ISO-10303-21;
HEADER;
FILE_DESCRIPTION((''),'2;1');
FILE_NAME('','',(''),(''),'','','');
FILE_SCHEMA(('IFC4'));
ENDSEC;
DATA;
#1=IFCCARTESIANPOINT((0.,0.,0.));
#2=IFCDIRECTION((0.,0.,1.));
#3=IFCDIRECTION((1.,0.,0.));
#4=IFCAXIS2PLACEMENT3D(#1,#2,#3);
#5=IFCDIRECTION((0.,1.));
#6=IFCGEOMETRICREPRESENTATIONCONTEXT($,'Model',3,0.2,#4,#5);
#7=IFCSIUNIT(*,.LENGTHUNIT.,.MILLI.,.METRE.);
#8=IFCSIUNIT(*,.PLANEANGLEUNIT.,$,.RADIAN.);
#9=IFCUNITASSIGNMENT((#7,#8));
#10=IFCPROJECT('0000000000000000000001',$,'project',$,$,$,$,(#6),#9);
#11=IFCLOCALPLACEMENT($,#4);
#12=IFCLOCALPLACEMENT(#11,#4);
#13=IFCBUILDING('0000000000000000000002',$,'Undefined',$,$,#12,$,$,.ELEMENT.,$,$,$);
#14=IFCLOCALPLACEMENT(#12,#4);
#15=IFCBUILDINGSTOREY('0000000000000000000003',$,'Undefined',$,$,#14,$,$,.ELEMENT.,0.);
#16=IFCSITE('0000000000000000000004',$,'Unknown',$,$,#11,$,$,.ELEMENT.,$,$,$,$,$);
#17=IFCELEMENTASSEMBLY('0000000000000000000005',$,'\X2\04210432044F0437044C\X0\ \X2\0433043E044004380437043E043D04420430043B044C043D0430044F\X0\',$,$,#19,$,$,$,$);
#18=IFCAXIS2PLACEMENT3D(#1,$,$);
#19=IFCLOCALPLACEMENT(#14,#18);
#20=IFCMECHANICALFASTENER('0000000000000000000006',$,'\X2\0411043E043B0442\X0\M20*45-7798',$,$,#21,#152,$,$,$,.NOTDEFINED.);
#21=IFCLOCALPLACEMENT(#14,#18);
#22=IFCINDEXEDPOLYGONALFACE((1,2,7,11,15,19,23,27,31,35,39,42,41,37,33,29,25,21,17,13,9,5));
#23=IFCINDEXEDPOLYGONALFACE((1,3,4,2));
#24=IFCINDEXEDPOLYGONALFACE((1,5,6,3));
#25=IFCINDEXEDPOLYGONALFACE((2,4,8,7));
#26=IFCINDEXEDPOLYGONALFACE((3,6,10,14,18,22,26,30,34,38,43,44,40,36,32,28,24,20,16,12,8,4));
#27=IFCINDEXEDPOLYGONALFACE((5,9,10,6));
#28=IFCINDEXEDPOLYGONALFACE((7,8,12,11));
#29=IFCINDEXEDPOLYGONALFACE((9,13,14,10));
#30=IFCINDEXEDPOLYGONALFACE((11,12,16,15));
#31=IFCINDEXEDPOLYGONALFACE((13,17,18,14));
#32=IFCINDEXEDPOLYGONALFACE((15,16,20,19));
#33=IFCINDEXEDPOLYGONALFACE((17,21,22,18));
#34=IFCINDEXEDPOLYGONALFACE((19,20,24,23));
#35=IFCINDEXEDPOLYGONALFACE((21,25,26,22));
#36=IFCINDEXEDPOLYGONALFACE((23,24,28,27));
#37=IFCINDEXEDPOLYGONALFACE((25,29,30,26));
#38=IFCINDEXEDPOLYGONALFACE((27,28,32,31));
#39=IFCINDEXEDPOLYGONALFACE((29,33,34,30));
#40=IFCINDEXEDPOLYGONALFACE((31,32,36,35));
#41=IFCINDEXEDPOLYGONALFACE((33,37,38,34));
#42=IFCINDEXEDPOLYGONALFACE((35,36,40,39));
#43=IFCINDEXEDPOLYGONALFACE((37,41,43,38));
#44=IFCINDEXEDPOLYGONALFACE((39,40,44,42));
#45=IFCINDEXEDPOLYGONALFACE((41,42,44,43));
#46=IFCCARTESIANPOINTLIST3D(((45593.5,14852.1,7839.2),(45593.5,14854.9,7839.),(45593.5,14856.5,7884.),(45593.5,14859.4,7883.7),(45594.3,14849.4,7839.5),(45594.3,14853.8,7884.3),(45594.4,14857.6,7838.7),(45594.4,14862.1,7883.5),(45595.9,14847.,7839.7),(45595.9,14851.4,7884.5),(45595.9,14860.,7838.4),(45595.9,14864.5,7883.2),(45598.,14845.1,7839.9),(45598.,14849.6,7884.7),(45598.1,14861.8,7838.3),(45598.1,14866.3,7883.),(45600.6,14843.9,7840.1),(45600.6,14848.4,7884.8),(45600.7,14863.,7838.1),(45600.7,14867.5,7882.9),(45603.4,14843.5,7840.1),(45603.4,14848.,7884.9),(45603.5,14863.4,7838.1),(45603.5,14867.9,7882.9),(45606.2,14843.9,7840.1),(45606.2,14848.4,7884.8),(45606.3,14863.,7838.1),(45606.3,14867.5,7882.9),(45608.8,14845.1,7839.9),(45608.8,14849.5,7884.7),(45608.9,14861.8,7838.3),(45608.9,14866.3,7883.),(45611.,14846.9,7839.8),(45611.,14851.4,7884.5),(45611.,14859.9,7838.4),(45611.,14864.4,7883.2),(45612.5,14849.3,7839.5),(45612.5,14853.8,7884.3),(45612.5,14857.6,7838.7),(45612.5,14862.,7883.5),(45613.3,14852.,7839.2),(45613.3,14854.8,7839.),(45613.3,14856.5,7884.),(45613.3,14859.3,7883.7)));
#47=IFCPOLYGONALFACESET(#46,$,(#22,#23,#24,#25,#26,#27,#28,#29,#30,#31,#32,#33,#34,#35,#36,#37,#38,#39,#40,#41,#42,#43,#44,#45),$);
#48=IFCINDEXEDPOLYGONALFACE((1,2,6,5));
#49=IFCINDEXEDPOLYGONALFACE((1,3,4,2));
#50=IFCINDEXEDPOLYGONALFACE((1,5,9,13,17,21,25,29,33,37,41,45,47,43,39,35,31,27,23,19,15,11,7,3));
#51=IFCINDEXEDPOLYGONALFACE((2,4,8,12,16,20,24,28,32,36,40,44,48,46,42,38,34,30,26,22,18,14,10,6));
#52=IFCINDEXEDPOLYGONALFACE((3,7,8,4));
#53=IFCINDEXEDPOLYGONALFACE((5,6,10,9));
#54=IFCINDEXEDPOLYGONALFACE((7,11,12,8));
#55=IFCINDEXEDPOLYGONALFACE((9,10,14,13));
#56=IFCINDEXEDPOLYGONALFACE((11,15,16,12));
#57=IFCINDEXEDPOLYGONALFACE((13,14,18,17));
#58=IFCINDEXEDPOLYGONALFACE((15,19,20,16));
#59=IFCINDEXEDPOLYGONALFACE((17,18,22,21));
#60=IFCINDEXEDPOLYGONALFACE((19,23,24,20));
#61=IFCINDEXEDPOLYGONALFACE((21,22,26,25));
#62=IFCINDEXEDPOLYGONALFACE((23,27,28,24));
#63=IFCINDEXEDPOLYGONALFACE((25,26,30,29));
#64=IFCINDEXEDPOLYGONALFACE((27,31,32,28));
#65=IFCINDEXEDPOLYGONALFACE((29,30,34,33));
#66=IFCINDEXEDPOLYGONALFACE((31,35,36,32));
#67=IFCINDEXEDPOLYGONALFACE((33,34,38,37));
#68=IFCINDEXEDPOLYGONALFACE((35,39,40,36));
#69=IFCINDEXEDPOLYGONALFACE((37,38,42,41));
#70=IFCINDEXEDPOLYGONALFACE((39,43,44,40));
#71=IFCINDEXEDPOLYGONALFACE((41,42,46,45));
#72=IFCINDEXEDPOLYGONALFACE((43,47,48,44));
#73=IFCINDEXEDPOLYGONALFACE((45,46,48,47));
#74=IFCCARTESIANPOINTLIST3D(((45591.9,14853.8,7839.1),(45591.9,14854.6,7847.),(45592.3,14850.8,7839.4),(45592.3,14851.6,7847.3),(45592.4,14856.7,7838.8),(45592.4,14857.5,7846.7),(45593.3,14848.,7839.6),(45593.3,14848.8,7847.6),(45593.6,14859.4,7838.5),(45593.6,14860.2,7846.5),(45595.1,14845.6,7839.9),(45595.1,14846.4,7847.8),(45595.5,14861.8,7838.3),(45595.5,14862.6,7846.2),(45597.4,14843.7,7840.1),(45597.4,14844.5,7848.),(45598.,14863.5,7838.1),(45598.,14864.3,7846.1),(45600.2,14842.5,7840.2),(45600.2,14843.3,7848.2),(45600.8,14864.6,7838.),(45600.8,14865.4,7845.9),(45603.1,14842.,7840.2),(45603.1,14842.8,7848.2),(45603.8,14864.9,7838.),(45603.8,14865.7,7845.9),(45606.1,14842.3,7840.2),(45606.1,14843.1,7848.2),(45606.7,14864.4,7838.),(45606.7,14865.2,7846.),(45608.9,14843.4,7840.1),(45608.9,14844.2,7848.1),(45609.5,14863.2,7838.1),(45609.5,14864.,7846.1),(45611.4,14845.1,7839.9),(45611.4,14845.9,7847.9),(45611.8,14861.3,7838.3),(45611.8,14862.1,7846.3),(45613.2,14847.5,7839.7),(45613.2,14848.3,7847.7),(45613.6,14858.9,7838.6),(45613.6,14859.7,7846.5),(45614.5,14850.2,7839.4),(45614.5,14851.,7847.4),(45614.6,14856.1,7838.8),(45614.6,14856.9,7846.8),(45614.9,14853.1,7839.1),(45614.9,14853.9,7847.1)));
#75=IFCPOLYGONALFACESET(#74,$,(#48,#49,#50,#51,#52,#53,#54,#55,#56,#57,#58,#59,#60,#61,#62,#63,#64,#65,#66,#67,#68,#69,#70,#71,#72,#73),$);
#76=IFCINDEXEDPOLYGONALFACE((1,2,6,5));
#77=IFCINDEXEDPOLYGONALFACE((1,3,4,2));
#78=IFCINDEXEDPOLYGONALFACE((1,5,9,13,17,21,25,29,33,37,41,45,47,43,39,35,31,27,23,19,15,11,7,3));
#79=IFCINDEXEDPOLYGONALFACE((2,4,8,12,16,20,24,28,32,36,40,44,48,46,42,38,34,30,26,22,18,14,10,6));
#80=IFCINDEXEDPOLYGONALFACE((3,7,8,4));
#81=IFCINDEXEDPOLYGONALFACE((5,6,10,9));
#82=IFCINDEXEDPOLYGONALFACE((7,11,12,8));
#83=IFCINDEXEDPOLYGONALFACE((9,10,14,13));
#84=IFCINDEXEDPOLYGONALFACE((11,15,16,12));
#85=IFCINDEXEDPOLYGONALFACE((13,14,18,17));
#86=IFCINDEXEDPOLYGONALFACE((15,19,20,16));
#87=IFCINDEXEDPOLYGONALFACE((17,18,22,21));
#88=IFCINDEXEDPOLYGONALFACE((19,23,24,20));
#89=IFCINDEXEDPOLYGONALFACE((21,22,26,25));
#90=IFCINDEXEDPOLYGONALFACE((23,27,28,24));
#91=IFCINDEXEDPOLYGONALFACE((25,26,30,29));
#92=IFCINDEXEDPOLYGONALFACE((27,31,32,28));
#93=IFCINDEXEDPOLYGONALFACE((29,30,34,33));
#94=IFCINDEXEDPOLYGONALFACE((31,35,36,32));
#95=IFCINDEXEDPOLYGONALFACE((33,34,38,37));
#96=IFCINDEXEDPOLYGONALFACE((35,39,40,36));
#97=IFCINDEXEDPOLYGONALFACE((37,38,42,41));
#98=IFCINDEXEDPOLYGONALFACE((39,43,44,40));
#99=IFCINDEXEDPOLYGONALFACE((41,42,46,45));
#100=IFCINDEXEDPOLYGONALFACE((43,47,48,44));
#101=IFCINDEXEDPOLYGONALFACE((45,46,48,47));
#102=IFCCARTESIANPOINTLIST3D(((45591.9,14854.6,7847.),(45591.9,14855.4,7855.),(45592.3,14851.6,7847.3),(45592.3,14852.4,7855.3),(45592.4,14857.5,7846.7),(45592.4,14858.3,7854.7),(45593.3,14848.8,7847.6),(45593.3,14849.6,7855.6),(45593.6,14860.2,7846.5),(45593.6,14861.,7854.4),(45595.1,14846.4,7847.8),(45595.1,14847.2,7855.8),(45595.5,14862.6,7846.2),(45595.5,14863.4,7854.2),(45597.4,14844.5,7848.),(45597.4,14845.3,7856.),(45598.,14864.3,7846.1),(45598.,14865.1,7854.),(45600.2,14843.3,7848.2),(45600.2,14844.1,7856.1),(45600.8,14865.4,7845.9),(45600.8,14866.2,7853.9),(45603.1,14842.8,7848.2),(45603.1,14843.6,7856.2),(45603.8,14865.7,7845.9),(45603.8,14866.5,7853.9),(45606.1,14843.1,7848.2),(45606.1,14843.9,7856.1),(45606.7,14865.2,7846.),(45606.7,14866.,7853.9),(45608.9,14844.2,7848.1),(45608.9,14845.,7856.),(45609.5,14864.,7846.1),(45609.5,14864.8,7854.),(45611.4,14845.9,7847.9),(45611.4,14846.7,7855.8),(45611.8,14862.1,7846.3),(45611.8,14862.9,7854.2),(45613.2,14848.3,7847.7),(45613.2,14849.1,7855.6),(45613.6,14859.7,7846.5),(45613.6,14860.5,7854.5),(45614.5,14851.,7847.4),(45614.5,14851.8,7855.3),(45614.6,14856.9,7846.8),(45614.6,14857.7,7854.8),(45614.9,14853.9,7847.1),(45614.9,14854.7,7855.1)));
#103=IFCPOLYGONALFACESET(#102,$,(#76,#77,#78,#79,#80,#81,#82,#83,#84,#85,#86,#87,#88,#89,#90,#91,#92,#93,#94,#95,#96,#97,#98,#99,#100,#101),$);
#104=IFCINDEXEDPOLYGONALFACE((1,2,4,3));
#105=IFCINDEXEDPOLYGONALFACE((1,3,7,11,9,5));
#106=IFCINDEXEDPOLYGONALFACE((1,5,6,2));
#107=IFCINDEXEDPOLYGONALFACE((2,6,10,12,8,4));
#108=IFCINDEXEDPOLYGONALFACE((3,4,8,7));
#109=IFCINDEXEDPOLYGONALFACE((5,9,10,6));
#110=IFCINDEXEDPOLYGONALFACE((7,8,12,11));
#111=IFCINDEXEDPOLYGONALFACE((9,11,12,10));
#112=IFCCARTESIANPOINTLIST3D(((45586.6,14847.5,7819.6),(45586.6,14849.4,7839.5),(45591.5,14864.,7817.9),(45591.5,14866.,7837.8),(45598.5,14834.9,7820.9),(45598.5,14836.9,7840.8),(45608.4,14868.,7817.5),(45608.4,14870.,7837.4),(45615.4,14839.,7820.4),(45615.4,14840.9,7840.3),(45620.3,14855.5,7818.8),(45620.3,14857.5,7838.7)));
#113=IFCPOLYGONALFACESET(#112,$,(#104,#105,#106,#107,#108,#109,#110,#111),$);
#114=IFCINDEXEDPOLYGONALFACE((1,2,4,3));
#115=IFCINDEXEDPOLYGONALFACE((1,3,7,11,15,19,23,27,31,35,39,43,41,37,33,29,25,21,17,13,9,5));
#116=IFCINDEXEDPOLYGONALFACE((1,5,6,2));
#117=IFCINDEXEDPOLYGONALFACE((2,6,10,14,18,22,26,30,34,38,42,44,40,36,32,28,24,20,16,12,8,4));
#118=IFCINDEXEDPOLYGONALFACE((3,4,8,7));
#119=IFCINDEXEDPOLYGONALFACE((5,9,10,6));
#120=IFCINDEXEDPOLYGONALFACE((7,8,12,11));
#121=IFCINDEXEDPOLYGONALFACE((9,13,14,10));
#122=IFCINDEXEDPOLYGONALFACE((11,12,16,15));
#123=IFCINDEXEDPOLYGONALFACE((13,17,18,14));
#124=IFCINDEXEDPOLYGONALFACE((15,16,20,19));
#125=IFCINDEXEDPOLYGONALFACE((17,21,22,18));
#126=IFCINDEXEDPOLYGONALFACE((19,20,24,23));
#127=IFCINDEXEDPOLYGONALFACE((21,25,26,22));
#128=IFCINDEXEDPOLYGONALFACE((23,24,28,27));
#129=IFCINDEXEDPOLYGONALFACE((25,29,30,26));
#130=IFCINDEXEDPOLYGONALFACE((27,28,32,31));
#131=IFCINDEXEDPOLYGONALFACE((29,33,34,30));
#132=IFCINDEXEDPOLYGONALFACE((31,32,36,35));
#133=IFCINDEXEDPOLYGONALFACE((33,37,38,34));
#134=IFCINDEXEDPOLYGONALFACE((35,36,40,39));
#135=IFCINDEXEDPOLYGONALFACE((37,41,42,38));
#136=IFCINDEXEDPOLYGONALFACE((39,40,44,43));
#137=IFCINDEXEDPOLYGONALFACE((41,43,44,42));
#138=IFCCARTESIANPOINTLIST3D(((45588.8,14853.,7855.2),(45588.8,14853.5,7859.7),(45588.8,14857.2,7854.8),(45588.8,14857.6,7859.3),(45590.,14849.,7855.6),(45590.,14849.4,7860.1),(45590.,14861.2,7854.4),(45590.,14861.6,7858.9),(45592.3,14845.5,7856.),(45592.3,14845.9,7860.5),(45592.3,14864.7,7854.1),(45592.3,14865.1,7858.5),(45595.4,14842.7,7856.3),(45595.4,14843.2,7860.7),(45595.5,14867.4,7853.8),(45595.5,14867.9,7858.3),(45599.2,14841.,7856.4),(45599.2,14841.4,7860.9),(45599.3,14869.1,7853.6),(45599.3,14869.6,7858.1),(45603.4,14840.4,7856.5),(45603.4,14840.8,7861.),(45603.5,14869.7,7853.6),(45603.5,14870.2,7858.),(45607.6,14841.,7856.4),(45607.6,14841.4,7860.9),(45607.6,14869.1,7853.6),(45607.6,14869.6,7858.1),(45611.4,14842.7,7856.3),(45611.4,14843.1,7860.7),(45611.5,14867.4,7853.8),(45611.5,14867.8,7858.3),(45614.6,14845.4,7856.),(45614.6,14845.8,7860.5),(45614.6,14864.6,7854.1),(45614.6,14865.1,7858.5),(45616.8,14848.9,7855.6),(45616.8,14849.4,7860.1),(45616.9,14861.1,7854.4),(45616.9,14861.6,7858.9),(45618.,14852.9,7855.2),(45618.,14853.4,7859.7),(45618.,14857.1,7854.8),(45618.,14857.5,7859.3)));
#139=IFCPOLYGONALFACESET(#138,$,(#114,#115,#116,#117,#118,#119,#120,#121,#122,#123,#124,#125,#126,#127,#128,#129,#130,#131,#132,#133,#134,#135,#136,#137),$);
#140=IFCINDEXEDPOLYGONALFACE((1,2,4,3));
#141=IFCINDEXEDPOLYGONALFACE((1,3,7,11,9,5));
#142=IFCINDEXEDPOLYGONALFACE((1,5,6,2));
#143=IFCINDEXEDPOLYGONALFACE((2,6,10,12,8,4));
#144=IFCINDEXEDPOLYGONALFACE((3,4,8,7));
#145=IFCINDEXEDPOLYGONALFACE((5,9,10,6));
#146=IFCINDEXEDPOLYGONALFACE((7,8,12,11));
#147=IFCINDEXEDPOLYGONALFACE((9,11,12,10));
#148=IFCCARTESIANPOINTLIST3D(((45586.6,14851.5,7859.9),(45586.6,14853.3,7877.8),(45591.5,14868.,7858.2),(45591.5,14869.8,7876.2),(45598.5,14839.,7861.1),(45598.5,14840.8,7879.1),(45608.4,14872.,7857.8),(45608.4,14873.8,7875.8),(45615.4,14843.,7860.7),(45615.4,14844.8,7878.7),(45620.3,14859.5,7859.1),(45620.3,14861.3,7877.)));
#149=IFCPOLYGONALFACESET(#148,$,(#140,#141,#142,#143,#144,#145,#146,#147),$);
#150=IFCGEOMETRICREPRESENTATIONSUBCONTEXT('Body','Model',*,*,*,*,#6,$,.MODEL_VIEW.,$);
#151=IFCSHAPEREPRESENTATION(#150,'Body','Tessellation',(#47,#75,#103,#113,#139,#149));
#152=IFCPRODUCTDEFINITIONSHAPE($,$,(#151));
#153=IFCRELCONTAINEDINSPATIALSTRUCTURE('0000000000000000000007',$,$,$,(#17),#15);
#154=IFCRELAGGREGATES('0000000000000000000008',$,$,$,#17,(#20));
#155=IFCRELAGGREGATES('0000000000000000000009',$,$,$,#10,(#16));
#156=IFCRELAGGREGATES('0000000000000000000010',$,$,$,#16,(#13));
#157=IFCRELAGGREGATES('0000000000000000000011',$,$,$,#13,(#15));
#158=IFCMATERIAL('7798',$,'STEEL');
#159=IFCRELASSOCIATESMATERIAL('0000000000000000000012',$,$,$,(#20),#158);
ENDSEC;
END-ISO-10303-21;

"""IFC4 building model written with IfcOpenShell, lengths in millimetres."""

from ifc_helpers import new_model, si_unit, direction, frame, origin_with_axes, place, context, subcontext, project, spatial, line, arc, indexed_curve, outline, extrude, source, transform, mapped, material, element, aggregate, save


model = new_model("IFC4")

# Units and contexts
model_context = context("Model", 3, precision=0.2, world=origin_with_axes(), true_north=direction((0.0, 1.0)))
body_context = subcontext(model_context, "Body", "Model", "MODEL_VIEW")
ifc_project = project(units=[si_unit("LENGTHUNIT", "METRE", prefix="MILLI"), si_unit("PLANEANGLEUNIT", "RADIAN")], contexts=[model_context])

# Site, building, storey
site_placement = place(None, origin_with_axes())
site = spatial("IfcSite", under=ifc_project, at=site_placement, Name="Unknown", CompositionType="ELEMENT")
building_placement = place(site_placement, origin_with_axes())
building = spatial("IfcBuilding", under=site, at=building_placement, Name="Undefined", CompositionType="ELEMENT")
storey_placement = place(building_placement, origin_with_axes())
storey = spatial("IfcBuildingStorey", under=building, at=storey_placement, Name="Undefined", CompositionType="ELEMENT", Elevation=0.0)

# Element assembly
assembly_1_placement = place(storey_placement, frame((44657.9, 15134.1, 7823.1), z_axis=(-0.28473, -0.95385, 0.095385), x_axis=(0.958608, -0.283317, 0.028332)))
assembly_1 = element("IfcElementAssembly", 1, at=assembly_1_placement, inside=storey, Name="Связь горизонтальная")

# Mechanical fastener
ifc_material_1 = material(Name="7798", Category="STEEL")
shared_shape_1 = source(origin_with_axes(), body_context, "Body", "SweptSolid", [
    extrude(outline(indexed_curve([(10.0, 0.0), (0.0, 10.0), (-10.0, 0.0), (0.0, -10.0)], segments=[arc(1, 2, 3), arc(3, 4, 1)])), frame((0.0, 0.0, 12.0), z_axis=(0.0, 0.0, -1.0), x_axis=(0.0, 1.0, 0.0)), (0.0, 0.0, 1.0), 45.0),
    extrude(outline(indexed_curve([(0.0, 11.5), (8.1, 8.1), (11.5, 0.0), (8.1, -8.1), (0.0, -11.5), (-1.0, -11.5), (-11.5, 0.0), (-8.1, 8.1)], segments=[arc(1, 2, 3), arc(3, 4, 5), arc(5, 6, 7), arc(7, 8, 1)])), frame((0.0, 0.0, 12.0), z_axis=(0.0, 0.0, -1.0), x_axis=(0.0, 1.0, 0.0)), (0.0, 0.0, 1.0), 8.0),
    extrude(outline(indexed_curve([(0.0, 11.5), (8.1, 8.1), (11.5, 0.0), (8.1, -8.1), (0.0, -11.5), (-1.0, -11.5), (-11.5, 0.0), (-8.1, 8.1)], segments=[arc(1, 2, 3), arc(3, 4, 5), arc(5, 6, 7), arc(7, 8, 1)])), frame((0.0, 0.0, 4.0), z_axis=(0.0, 0.0, -1.0), x_axis=(0.0, 1.0, 0.0)), (0.0, 0.0, 1.0), 8.0),
    extrude(outline(indexed_curve([(17.3, 0.0), (8.7, 15.0), (-8.7, 15.0), (-17.3, 0.0), (-8.7, -15.0), (8.7, -15.0)], segments=[line(1, 2, 3, 4, 5, 6, 1)])), frame((0.0, 0.0, 32.0), z_axis=(0.0, 0.0, -1.0), x_axis=(0.0, 1.0, 0.0)), (0.0, 0.0, 1.0), 20.0),
    extrude(outline(indexed_curve([(14.8, 0.0), (0.0, 14.8), (-14.8, 0.0), (0.0, -14.8)], segments=[arc(1, 2, 3), arc(3, 4, 1)])), frame((0.0, 0.0, -4.0), z_axis=(0.0, 0.0, -1.0), x_axis=(0.0, 1.0, 0.0)), (0.0, 0.0, 1.0), 4.5),
    extrude(outline(indexed_curve([(17.3, 0.0), (8.7, 15.0), (-8.7, 15.0), (-17.3, 0.0), (-8.7, -15.0), (8.7, -15.0)], segments=[line(1, 2, 3, 4, 5, 6, 1)])), frame((0.0, 0.0, -8.5), z_axis=(0.0, 0.0, -1.0), x_axis=(0.0, 1.0, 0.0)), (0.0, 0.0, 1.0), 18.0),
])
mechanical_fastener_1_placement = place(assembly_1_placement, frame((986.3, 0.0, 0.0), z_axis=(0.0, -1.0, 0.0), x_axis=(-1.0, 0.0, 0.0)))
mechanical_fastener_1 = element("IfcMechanicalFastener", 2, at=mechanical_fastener_1_placement, material=ifc_material_1, Name="БолтM20*45-7798", PredefinedType="NOTDEFINED", context=body_context, shape_type="MappedRepresentation", body=[
    mapped(shared_shape_1, transform((0.0, 0.0, 0.0))),
])
aggregate(assembly_1, [mechanical_fastener_1])

save(model, "model.ifc")
